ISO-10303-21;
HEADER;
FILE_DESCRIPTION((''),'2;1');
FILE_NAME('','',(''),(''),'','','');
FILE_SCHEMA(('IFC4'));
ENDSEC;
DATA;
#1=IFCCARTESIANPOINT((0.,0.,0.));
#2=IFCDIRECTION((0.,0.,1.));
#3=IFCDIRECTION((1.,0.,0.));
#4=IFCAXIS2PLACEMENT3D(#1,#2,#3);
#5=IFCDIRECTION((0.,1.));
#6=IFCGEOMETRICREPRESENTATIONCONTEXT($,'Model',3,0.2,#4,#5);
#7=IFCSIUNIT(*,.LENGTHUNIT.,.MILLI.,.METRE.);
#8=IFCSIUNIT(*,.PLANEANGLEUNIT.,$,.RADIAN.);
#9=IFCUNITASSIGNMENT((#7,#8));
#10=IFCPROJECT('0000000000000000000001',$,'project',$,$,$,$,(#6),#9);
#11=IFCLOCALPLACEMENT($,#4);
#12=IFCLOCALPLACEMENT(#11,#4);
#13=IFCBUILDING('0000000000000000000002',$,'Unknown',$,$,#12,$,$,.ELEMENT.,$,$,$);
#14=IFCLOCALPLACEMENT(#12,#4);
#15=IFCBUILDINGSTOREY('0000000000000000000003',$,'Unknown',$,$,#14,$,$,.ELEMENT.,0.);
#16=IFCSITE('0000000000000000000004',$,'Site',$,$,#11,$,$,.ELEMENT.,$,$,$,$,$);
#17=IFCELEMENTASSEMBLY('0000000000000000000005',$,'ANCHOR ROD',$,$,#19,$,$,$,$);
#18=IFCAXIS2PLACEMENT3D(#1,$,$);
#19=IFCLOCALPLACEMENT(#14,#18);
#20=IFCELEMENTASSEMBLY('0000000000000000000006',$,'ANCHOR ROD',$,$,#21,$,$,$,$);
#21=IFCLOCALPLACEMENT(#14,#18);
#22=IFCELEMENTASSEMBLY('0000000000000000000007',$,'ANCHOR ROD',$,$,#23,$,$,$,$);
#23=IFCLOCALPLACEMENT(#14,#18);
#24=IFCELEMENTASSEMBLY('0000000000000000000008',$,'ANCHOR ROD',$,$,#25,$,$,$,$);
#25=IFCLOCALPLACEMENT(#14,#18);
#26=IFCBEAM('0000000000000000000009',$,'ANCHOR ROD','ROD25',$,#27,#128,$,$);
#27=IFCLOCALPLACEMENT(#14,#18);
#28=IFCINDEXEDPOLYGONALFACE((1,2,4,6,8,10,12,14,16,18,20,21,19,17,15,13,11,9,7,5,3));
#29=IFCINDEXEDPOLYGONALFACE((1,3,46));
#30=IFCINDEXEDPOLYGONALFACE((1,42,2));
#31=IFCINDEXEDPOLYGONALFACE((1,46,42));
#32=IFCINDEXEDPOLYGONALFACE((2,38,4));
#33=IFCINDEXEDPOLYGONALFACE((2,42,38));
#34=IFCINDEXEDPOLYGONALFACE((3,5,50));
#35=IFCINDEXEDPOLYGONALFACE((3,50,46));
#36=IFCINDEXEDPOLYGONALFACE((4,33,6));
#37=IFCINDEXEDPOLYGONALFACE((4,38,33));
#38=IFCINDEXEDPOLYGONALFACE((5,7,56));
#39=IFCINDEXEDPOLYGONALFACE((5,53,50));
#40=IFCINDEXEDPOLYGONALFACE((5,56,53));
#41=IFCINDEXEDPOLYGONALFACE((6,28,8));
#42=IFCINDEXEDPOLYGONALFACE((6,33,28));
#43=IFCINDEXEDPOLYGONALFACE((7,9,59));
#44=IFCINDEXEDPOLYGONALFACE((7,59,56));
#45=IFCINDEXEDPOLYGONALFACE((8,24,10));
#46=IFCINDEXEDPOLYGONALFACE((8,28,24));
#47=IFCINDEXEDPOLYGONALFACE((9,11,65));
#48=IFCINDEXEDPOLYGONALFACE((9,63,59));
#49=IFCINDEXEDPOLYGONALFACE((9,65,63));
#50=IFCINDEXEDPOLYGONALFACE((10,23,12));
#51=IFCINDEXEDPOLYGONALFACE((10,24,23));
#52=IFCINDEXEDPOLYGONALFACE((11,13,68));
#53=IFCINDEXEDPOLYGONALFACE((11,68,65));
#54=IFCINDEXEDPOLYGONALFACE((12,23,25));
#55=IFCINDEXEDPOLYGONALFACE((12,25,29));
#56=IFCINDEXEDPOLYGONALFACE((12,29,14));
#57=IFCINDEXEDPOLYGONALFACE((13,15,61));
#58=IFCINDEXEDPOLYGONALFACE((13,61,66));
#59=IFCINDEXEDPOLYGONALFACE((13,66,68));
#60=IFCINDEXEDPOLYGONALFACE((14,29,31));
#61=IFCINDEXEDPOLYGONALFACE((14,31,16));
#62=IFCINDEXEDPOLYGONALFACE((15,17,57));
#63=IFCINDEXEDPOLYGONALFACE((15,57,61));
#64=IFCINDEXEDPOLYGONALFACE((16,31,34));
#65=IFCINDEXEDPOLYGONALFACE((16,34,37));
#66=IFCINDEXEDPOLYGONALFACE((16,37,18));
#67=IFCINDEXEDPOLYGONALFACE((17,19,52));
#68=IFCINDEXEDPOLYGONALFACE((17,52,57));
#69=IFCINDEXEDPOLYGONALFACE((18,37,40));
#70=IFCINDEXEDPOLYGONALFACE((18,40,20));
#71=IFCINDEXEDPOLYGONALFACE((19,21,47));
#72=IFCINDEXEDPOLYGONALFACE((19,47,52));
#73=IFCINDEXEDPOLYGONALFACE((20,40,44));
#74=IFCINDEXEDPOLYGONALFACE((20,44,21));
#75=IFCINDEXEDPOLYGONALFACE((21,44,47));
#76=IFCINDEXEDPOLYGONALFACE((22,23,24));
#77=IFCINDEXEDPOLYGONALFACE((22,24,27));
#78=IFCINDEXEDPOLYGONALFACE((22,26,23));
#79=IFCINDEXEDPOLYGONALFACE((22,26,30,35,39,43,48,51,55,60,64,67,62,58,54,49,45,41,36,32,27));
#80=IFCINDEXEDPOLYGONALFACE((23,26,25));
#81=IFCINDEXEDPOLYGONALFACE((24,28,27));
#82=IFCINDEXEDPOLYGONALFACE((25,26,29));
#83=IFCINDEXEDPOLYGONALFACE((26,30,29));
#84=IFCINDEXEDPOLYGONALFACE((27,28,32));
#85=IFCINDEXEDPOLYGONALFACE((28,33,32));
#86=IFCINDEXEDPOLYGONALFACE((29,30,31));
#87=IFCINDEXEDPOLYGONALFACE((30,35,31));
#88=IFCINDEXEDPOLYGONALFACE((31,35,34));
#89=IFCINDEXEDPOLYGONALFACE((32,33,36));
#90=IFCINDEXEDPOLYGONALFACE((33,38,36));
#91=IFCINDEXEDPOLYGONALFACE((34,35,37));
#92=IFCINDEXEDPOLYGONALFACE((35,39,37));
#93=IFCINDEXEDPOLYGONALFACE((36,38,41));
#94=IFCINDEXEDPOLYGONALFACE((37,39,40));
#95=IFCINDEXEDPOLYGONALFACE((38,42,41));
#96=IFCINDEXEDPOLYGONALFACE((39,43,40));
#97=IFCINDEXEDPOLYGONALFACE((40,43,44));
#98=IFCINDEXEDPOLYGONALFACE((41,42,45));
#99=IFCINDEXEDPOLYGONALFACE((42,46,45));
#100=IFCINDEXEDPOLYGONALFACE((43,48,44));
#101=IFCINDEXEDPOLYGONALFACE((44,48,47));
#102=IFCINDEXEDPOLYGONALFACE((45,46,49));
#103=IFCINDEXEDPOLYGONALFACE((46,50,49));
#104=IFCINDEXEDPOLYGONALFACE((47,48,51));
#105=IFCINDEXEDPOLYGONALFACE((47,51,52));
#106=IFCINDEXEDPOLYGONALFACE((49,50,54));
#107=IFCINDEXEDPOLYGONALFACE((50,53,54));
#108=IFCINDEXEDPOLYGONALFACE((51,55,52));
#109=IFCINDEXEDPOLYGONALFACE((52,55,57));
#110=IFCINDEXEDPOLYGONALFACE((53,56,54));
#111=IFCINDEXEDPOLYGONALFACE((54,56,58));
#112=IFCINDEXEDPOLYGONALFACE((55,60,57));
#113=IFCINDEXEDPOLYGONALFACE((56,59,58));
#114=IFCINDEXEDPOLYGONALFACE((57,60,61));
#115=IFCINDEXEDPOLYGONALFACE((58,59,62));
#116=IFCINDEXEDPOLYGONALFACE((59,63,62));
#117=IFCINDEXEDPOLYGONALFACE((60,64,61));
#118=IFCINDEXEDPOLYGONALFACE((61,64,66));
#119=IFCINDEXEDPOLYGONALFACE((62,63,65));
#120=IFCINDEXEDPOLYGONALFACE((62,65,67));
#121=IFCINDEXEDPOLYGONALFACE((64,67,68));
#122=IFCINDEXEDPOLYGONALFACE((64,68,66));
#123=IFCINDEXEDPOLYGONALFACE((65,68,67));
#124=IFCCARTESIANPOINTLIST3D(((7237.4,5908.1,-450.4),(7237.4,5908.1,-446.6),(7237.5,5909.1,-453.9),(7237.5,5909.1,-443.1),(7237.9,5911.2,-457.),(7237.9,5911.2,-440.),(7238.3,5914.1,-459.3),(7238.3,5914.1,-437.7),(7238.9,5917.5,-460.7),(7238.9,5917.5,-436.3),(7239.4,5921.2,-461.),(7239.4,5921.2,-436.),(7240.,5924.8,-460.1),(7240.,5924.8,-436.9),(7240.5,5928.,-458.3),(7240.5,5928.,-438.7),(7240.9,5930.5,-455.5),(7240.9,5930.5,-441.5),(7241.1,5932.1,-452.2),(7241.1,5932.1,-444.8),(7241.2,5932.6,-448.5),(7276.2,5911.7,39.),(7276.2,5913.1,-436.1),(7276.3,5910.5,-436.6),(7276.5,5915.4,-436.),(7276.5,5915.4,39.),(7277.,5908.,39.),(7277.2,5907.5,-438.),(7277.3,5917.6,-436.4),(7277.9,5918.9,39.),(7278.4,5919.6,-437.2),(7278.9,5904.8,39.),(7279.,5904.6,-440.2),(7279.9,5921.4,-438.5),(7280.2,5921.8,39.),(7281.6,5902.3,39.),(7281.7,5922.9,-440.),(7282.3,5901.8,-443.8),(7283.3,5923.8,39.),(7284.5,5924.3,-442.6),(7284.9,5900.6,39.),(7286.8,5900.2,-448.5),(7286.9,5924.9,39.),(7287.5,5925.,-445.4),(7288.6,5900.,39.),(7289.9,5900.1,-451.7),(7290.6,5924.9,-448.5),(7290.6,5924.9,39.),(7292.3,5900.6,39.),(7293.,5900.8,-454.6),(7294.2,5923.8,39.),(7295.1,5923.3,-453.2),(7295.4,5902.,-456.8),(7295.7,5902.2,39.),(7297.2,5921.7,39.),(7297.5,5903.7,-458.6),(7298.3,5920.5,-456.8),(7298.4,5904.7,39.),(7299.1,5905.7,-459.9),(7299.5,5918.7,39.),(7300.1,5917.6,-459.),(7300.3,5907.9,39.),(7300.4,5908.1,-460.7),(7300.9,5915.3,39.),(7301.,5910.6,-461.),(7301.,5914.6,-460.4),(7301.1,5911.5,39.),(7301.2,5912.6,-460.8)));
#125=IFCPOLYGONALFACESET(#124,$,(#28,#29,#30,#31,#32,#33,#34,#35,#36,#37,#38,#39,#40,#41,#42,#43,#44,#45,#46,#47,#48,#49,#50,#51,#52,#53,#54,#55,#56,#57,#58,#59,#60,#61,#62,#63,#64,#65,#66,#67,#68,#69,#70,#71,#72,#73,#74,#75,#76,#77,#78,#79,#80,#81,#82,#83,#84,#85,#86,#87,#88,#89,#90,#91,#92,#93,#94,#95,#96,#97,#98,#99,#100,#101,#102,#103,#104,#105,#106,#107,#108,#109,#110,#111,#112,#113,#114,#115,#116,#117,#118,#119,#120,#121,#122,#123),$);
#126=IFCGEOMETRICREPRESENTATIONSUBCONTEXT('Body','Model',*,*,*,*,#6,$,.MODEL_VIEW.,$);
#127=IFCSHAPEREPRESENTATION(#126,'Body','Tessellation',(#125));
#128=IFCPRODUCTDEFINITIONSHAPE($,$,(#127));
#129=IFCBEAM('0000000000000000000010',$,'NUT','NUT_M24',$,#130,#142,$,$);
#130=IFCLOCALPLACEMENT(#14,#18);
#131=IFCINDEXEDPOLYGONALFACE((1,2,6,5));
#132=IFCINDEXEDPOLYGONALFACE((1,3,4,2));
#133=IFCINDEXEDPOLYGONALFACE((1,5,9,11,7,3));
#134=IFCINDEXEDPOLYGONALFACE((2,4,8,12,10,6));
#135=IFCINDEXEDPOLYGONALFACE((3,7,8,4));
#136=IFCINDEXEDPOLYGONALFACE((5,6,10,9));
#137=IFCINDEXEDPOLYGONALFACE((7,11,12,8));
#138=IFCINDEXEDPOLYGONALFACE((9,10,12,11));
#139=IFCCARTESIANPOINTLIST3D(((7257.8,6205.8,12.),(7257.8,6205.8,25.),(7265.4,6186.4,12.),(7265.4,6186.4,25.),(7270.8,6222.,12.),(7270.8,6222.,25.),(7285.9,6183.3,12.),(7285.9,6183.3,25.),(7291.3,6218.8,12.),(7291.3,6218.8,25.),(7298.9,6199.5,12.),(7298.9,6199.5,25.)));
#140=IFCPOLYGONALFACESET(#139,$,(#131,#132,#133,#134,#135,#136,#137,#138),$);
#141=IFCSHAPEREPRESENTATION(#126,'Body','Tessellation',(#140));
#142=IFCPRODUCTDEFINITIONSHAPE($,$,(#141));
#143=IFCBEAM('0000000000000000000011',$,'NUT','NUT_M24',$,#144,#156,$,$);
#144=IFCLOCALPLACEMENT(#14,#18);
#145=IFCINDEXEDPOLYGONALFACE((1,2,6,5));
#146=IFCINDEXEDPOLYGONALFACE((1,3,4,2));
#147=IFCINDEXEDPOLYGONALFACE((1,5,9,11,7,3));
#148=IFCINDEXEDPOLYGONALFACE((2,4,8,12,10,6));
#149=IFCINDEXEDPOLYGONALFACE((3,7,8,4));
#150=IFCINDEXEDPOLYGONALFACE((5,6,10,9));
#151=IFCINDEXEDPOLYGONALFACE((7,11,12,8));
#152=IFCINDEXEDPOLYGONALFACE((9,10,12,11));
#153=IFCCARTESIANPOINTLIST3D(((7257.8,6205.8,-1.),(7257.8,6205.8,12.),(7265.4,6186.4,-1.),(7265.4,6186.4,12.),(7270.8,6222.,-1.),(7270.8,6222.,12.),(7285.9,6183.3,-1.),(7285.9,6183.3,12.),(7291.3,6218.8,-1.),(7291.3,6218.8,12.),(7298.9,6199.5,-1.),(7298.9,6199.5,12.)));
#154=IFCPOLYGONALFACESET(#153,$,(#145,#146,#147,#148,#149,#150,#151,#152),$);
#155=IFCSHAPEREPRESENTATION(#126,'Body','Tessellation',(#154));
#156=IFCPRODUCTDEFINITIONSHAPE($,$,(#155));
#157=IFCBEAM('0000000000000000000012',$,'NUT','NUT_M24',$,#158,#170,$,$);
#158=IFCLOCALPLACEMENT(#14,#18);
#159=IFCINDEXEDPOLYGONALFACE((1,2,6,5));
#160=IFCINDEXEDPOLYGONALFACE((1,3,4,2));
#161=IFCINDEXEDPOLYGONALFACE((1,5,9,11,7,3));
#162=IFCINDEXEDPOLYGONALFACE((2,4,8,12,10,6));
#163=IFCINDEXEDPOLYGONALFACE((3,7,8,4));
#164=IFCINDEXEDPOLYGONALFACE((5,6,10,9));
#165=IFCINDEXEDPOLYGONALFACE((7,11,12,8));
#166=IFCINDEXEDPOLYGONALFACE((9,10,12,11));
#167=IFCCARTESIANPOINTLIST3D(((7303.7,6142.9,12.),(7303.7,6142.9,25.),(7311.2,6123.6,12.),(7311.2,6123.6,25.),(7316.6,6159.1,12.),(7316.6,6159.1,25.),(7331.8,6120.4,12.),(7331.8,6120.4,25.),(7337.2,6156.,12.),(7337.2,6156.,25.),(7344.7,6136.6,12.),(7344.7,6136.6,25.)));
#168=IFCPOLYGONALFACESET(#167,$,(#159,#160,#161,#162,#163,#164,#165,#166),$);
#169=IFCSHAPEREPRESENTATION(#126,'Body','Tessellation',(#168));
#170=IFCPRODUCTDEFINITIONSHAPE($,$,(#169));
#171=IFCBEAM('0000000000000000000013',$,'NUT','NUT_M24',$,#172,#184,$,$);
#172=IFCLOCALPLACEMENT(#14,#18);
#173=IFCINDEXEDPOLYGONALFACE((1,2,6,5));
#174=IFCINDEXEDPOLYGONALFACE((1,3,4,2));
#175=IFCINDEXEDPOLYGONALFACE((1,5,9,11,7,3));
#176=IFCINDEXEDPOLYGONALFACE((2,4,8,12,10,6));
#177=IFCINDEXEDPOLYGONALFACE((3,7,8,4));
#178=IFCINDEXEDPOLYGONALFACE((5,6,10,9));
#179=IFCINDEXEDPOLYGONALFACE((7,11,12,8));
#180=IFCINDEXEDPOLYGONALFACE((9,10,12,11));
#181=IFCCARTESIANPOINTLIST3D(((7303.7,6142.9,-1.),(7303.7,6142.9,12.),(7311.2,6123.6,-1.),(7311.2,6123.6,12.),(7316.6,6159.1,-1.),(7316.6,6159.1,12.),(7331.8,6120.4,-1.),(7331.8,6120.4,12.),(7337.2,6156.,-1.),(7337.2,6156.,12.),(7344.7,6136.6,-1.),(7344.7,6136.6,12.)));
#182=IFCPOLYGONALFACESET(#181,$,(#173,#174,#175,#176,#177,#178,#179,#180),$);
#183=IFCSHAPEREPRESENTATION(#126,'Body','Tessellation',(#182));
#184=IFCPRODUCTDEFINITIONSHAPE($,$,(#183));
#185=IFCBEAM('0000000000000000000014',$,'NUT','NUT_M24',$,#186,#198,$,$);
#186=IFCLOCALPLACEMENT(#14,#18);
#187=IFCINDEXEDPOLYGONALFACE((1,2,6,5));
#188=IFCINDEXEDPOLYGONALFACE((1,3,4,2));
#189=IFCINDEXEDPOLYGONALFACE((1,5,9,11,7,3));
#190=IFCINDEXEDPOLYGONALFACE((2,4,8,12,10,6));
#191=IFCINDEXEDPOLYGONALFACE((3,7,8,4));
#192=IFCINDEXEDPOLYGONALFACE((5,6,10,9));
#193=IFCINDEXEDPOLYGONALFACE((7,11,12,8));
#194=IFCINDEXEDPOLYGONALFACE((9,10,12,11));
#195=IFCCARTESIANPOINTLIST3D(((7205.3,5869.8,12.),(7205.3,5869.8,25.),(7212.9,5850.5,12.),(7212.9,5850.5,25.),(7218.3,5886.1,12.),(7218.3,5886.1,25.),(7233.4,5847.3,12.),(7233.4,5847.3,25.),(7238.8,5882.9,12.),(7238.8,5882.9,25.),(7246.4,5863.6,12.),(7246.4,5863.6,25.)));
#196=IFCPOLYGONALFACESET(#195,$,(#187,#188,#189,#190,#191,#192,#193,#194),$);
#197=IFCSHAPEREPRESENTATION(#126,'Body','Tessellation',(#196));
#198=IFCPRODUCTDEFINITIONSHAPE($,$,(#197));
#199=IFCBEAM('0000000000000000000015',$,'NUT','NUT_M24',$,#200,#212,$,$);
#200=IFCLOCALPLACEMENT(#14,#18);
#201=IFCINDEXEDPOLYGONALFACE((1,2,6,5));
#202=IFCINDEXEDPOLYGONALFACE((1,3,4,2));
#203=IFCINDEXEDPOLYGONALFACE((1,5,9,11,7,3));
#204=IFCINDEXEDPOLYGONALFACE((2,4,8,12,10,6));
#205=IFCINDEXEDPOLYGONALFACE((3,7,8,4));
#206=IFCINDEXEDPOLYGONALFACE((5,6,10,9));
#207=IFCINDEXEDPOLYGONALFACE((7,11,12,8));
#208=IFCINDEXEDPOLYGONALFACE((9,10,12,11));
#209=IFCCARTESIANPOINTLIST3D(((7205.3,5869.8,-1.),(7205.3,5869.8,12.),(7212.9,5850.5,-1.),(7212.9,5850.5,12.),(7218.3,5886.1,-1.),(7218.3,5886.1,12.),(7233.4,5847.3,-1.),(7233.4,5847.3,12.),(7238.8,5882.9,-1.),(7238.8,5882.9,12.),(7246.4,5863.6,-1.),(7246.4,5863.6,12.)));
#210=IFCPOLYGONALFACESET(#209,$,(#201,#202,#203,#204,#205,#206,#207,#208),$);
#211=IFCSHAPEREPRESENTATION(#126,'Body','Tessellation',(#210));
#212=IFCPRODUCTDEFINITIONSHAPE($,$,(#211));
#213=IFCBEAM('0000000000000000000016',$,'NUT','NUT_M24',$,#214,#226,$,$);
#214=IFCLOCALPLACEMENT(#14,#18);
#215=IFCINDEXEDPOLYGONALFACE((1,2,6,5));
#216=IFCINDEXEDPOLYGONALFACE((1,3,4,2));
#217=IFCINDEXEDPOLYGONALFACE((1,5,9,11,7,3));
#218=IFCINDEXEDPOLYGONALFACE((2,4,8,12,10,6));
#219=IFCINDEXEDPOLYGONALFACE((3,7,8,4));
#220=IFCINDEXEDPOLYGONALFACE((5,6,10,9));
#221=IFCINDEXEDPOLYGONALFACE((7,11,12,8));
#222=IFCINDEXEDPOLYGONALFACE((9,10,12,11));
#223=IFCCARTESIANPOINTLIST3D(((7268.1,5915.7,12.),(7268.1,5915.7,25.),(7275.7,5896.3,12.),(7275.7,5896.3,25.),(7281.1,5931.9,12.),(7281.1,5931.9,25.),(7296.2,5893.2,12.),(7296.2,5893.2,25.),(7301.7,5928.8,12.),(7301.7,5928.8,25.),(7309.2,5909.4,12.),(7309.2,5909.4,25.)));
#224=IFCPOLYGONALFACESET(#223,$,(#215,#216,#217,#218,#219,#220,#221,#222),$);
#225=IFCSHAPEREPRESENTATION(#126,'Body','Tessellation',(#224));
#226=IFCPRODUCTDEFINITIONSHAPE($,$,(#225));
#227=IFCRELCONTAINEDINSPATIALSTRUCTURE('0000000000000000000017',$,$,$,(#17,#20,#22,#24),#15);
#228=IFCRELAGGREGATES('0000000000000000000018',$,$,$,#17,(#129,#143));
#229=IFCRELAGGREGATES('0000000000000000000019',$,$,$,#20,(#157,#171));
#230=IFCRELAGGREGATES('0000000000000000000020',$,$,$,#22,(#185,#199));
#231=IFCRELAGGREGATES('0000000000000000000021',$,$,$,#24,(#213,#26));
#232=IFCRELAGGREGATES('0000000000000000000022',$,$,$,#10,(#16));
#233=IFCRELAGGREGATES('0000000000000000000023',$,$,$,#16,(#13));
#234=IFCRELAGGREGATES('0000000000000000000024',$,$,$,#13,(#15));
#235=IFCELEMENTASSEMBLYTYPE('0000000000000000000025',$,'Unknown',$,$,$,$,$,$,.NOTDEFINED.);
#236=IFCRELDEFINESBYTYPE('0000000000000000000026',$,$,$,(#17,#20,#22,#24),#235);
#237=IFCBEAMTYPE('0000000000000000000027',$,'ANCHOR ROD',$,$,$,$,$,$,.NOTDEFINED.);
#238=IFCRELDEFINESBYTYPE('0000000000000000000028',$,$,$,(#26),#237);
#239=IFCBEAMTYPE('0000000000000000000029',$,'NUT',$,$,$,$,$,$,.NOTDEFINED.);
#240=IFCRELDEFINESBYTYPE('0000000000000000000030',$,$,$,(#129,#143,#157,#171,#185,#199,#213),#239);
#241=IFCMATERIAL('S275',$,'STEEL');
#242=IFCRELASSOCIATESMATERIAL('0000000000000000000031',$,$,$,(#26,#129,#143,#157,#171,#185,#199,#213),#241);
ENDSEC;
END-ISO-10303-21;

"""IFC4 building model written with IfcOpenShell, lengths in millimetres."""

from ifc_helpers import new_model, entity, si_unit, direction, frame, origin_with_axes, place, context, subcontext, project, spatial, polyline, outline, extrude, material, material_profile, profile_set, profile_usage, type_object, element, aggregate, save


model = new_model("IFC4")

# Units and contexts
model_context = context("Model", 3, precision=0.2, world=origin_with_axes(), true_north=direction((0.0, 1.0)))
body_context = subcontext(model_context, "Body", "Model", "MODEL_VIEW")
ifc_project = project(units=[si_unit("LENGTHUNIT", "METRE", prefix="MILLI"), si_unit("PLANEANGLEUNIT", "RADIAN")], contexts=[model_context])

# Site, building, storey
site_placement = place(None, origin_with_axes())
site = spatial("IfcSite", under=ifc_project, at=site_placement, Name="Site", CompositionType="ELEMENT")
building_placement = place(site_placement, origin_with_axes())
building = spatial("IfcBuilding", under=site, at=building_placement, Name="Unknown", CompositionType="ELEMENT")
storey_placement = place(building_placement, origin_with_axes())
storey = spatial("IfcBuildingStorey", under=building, at=storey_placement, Name="Unknown", CompositionType="ELEMENT", Elevation=0.0)

# Element assemblies
element_assembly_type = type_object("IfcElementAssemblyType", Name="Unknown", PredefinedType="NOTDEFINED")
assembly_1_placement = place(storey_placement, frame((7278.4, 6202.6, 39.0), z_axis=(0.154417, 0.988006, 0.0), x_axis=(0.0, 0.0, -1.0)))
assembly_1 = element("IfcElementAssembly", 1, at=assembly_1_placement, inside=storey, type_object=element_assembly_type, Name="ANCHOR ROD")
ifc_material_1 = material(Name="S275", Category="STEEL")
assembly_2_placement = place(storey_placement, frame((7324.2, 6139.8, 39.0), z_axis=(0.154417, 0.988006, 0.0), x_axis=(0.0, 0.0, -1.0)))
assembly_2 = element("IfcElementAssembly", 2, at=assembly_2_placement, inside=storey, type_object=element_assembly_type, Name="ANCHOR ROD")
assembly_3_placement = place(storey_placement, frame((7225.8, 5866.7, 39.0), z_axis=(0.154419, 0.988005, 0.0), x_axis=(0.0, 0.0, -1.0)))
assembly_3 = element("IfcElementAssembly", 3, at=assembly_3_placement, inside=storey, type_object=element_assembly_type, Name="ANCHOR ROD")
assembly_4_placement = place(storey_placement, frame((7288.7, 5912.5, 39.0), z_axis=(0.154419, 0.988005, 0.0), x_axis=(0.0, 0.0, -1.0)))
assembly_4 = element("IfcElementAssembly", 4, at=assembly_4_placement, inside=storey, type_object=element_assembly_type, Name="ANCHOR ROD")

# Beams
beam_type_1 = type_object("IfcBeamType", Name="ANCHOR ROD", PredefinedType="NOTDEFINED")
beam_1_placement = place(assembly_4_placement, origin_with_axes())
beam_1 = element("IfcBeam", 5, at=beam_1_placement, type_object=beam_type_1, material=ifc_material_1, Name="ANCHOR ROD", Description="ROD25", context=body_context, shape_type="SolidModel", body=[
    entity("IfcSweptDiskSolid", entity("IfcIndexedPolyCurve", entity("IfcCartesianPointList3D", [[0.0, 0.0, 0.0], [487.5, 0.0, 0.0], [487.5, 50.0, 0.0]]), [entity("IfcLineIndex", [1, 2, 3])]), 12.5),
])
ifc_material_profile_1 = material_profile(ifc_material_1, outline(polyline([(18.0, 10.4), (0.0, 20.8), (-18.0, 10.4), (-18.0, -10.4), (0.0, -20.8), (18.0, -10.4), (18.0, 10.4)])), Name="NUT_M24")
ifc_profile_set_1 = profile_set([ifc_material_profile_1])
ifc_profile_usage_1 = profile_usage(ifc_profile_set_1, cardinal=5)
beam_type_2 = type_object("IfcBeamType", Name="NUT", PredefinedType="NOTDEFINED")
beam_2_placement = place(assembly_1_placement, frame((14.0, 0.0, 0.0), z_axis=(0.0, 0.003454, 0.999994), x_axis=(1.0, 0.0, 0.0)))
beam_2 = element("IfcBeam", 6, at=beam_2_placement, type_object=beam_type_2, material=ifc_profile_usage_1, Name="NUT", Description="NUT_M24", context=body_context, shape_type="SolidModel", body=[
    extrude(outline(polyline([(18.0, 10.4), (0.0, 20.8), (-18.0, 10.4), (-18.0, -10.4), (0.0, -20.8), (18.0, -10.4), (18.0, 10.4)])), frame((0.0, 0.0, 0.0), z_axis=(-1.0, 0.0, 0.0), x_axis=(0.0, 0.0, 1.0)), (0.0, 0.0, -1.0), 13.0),
])
beam_3_placement = place(assembly_1_placement, frame((27.0, 0.0, 0.0), z_axis=(0.0, 0.003454, 0.999994), x_axis=(1.0, 0.0, 0.0)))
beam_3 = element("IfcBeam", 7, at=beam_3_placement, type_object=beam_type_2, material=ifc_profile_usage_1, Name="NUT", Description="NUT_M24", context=body_context, shape_type="SolidModel", body=[
    extrude(outline(polyline([(18.0, 10.4), (0.0, 20.8), (-18.0, 10.4), (-18.0, -10.4), (0.0, -20.8), (18.0, -10.4), (18.0, 10.4)])), frame((0.0, 0.0, 0.0), z_axis=(-1.0, 0.0, 0.0), x_axis=(0.0, 0.0, 1.0)), (0.0, 0.0, -1.0), 13.0),
])
aggregate(assembly_1, [beam_2, beam_3])
beam_4_placement = place(assembly_2_placement, frame((14.0, 0.0, 0.0), z_axis=(0.0, 0.003454, 0.999994), x_axis=(1.0, 0.0, 0.0)))
beam_4 = element("IfcBeam", 8, at=beam_4_placement, type_object=beam_type_2, material=ifc_profile_usage_1, Name="NUT", Description="NUT_M24", context=body_context, shape_type="SolidModel", body=[
    extrude(outline(polyline([(18.0, 10.4), (0.0, 20.8), (-18.0, 10.4), (-18.0, -10.4), (0.0, -20.8), (18.0, -10.4), (18.0, 10.4)])), frame((0.0, 0.0, 0.0), z_axis=(-1.0, 0.0, 0.0), x_axis=(0.0, 0.0, 1.0)), (0.0, 0.0, -1.0), 13.0),
])
beam_5_placement = place(assembly_2_placement, frame((27.0, 0.0, 0.0), z_axis=(0.0, 0.003454, 0.999994), x_axis=(1.0, 0.0, 0.0)))
beam_5 = element("IfcBeam", 9, at=beam_5_placement, type_object=beam_type_2, material=ifc_profile_usage_1, Name="NUT", Description="NUT_M24", context=body_context, shape_type="SolidModel", body=[
    extrude(outline(polyline([(18.0, 10.4), (0.0, 20.8), (-18.0, 10.4), (-18.0, -10.4), (0.0, -20.8), (18.0, -10.4), (18.0, 10.4)])), frame((0.0, 0.0, 0.0), z_axis=(-1.0, 0.0, 0.0), x_axis=(0.0, 0.0, 1.0)), (0.0, 0.0, -1.0), 13.0),
])
aggregate(assembly_2, [beam_4, beam_5])
beam_6_placement = place(assembly_3_placement, frame((14.0, 0.0, 0.0), z_axis=(0.0, 0.003456, 0.999994), x_axis=(1.0, 0.0, 0.0)))
beam_6 = element("IfcBeam", 10, at=beam_6_placement, type_object=beam_type_2, material=ifc_profile_usage_1, Name="NUT", Description="NUT_M24", context=body_context, shape_type="SolidModel", body=[
    extrude(outline(polyline([(18.0, 10.4), (0.0, 20.8), (-18.0, 10.4), (-18.0, -10.4), (0.0, -20.8), (18.0, -10.4), (18.0, 10.4)])), frame((0.0, 0.0, 0.0), z_axis=(-1.0, 0.0, 0.0), x_axis=(0.0, 0.0, 1.0)), (0.0, 0.0, -1.0), 13.0),
])
beam_7_placement = place(assembly_3_placement, frame((27.0, 0.0, 0.0), z_axis=(0.0, 0.003456, 0.999994), x_axis=(1.0, 0.0, 0.0)))
beam_7 = element("IfcBeam", 11, at=beam_7_placement, type_object=beam_type_2, material=ifc_profile_usage_1, Name="NUT", Description="NUT_M24", context=body_context, shape_type="SolidModel", body=[
    extrude(outline(polyline([(18.0, 10.4), (0.0, 20.8), (-18.0, 10.4), (-18.0, -10.4), (0.0, -20.8), (18.0, -10.4), (18.0, 10.4)])), frame((0.0, 0.0, 0.0), z_axis=(-1.0, 0.0, 0.0), x_axis=(0.0, 0.0, 1.0)), (0.0, 0.0, -1.0), 13.0),
])
aggregate(assembly_3, [beam_6, beam_7])
beam_8_placement = place(assembly_4_placement, frame((14.0, 0.0, 0.0), z_axis=(0.0, 0.003456, 0.999994), x_axis=(1.0, 0.0, 0.0)))
beam_8 = element("IfcBeam", 12, at=beam_8_placement, type_object=beam_type_2, material=ifc_profile_usage_1, Name="NUT", Description="NUT_M24", context=body_context, shape_type="SolidModel", body=[
    extrude(outline(polyline([(18.0, 10.4), (0.0, 20.8), (-18.0, 10.4), (-18.0, -10.4), (0.0, -20.8), (18.0, -10.4), (18.0, 10.4)])), frame((0.0, 0.0, 0.0), z_axis=(-1.0, 0.0, 0.0), x_axis=(0.0, 0.0, 1.0)), (0.0, 0.0, -1.0), 13.0),
])
aggregate(assembly_4, [beam_8, beam_1])

save(model, "model.ifc")
